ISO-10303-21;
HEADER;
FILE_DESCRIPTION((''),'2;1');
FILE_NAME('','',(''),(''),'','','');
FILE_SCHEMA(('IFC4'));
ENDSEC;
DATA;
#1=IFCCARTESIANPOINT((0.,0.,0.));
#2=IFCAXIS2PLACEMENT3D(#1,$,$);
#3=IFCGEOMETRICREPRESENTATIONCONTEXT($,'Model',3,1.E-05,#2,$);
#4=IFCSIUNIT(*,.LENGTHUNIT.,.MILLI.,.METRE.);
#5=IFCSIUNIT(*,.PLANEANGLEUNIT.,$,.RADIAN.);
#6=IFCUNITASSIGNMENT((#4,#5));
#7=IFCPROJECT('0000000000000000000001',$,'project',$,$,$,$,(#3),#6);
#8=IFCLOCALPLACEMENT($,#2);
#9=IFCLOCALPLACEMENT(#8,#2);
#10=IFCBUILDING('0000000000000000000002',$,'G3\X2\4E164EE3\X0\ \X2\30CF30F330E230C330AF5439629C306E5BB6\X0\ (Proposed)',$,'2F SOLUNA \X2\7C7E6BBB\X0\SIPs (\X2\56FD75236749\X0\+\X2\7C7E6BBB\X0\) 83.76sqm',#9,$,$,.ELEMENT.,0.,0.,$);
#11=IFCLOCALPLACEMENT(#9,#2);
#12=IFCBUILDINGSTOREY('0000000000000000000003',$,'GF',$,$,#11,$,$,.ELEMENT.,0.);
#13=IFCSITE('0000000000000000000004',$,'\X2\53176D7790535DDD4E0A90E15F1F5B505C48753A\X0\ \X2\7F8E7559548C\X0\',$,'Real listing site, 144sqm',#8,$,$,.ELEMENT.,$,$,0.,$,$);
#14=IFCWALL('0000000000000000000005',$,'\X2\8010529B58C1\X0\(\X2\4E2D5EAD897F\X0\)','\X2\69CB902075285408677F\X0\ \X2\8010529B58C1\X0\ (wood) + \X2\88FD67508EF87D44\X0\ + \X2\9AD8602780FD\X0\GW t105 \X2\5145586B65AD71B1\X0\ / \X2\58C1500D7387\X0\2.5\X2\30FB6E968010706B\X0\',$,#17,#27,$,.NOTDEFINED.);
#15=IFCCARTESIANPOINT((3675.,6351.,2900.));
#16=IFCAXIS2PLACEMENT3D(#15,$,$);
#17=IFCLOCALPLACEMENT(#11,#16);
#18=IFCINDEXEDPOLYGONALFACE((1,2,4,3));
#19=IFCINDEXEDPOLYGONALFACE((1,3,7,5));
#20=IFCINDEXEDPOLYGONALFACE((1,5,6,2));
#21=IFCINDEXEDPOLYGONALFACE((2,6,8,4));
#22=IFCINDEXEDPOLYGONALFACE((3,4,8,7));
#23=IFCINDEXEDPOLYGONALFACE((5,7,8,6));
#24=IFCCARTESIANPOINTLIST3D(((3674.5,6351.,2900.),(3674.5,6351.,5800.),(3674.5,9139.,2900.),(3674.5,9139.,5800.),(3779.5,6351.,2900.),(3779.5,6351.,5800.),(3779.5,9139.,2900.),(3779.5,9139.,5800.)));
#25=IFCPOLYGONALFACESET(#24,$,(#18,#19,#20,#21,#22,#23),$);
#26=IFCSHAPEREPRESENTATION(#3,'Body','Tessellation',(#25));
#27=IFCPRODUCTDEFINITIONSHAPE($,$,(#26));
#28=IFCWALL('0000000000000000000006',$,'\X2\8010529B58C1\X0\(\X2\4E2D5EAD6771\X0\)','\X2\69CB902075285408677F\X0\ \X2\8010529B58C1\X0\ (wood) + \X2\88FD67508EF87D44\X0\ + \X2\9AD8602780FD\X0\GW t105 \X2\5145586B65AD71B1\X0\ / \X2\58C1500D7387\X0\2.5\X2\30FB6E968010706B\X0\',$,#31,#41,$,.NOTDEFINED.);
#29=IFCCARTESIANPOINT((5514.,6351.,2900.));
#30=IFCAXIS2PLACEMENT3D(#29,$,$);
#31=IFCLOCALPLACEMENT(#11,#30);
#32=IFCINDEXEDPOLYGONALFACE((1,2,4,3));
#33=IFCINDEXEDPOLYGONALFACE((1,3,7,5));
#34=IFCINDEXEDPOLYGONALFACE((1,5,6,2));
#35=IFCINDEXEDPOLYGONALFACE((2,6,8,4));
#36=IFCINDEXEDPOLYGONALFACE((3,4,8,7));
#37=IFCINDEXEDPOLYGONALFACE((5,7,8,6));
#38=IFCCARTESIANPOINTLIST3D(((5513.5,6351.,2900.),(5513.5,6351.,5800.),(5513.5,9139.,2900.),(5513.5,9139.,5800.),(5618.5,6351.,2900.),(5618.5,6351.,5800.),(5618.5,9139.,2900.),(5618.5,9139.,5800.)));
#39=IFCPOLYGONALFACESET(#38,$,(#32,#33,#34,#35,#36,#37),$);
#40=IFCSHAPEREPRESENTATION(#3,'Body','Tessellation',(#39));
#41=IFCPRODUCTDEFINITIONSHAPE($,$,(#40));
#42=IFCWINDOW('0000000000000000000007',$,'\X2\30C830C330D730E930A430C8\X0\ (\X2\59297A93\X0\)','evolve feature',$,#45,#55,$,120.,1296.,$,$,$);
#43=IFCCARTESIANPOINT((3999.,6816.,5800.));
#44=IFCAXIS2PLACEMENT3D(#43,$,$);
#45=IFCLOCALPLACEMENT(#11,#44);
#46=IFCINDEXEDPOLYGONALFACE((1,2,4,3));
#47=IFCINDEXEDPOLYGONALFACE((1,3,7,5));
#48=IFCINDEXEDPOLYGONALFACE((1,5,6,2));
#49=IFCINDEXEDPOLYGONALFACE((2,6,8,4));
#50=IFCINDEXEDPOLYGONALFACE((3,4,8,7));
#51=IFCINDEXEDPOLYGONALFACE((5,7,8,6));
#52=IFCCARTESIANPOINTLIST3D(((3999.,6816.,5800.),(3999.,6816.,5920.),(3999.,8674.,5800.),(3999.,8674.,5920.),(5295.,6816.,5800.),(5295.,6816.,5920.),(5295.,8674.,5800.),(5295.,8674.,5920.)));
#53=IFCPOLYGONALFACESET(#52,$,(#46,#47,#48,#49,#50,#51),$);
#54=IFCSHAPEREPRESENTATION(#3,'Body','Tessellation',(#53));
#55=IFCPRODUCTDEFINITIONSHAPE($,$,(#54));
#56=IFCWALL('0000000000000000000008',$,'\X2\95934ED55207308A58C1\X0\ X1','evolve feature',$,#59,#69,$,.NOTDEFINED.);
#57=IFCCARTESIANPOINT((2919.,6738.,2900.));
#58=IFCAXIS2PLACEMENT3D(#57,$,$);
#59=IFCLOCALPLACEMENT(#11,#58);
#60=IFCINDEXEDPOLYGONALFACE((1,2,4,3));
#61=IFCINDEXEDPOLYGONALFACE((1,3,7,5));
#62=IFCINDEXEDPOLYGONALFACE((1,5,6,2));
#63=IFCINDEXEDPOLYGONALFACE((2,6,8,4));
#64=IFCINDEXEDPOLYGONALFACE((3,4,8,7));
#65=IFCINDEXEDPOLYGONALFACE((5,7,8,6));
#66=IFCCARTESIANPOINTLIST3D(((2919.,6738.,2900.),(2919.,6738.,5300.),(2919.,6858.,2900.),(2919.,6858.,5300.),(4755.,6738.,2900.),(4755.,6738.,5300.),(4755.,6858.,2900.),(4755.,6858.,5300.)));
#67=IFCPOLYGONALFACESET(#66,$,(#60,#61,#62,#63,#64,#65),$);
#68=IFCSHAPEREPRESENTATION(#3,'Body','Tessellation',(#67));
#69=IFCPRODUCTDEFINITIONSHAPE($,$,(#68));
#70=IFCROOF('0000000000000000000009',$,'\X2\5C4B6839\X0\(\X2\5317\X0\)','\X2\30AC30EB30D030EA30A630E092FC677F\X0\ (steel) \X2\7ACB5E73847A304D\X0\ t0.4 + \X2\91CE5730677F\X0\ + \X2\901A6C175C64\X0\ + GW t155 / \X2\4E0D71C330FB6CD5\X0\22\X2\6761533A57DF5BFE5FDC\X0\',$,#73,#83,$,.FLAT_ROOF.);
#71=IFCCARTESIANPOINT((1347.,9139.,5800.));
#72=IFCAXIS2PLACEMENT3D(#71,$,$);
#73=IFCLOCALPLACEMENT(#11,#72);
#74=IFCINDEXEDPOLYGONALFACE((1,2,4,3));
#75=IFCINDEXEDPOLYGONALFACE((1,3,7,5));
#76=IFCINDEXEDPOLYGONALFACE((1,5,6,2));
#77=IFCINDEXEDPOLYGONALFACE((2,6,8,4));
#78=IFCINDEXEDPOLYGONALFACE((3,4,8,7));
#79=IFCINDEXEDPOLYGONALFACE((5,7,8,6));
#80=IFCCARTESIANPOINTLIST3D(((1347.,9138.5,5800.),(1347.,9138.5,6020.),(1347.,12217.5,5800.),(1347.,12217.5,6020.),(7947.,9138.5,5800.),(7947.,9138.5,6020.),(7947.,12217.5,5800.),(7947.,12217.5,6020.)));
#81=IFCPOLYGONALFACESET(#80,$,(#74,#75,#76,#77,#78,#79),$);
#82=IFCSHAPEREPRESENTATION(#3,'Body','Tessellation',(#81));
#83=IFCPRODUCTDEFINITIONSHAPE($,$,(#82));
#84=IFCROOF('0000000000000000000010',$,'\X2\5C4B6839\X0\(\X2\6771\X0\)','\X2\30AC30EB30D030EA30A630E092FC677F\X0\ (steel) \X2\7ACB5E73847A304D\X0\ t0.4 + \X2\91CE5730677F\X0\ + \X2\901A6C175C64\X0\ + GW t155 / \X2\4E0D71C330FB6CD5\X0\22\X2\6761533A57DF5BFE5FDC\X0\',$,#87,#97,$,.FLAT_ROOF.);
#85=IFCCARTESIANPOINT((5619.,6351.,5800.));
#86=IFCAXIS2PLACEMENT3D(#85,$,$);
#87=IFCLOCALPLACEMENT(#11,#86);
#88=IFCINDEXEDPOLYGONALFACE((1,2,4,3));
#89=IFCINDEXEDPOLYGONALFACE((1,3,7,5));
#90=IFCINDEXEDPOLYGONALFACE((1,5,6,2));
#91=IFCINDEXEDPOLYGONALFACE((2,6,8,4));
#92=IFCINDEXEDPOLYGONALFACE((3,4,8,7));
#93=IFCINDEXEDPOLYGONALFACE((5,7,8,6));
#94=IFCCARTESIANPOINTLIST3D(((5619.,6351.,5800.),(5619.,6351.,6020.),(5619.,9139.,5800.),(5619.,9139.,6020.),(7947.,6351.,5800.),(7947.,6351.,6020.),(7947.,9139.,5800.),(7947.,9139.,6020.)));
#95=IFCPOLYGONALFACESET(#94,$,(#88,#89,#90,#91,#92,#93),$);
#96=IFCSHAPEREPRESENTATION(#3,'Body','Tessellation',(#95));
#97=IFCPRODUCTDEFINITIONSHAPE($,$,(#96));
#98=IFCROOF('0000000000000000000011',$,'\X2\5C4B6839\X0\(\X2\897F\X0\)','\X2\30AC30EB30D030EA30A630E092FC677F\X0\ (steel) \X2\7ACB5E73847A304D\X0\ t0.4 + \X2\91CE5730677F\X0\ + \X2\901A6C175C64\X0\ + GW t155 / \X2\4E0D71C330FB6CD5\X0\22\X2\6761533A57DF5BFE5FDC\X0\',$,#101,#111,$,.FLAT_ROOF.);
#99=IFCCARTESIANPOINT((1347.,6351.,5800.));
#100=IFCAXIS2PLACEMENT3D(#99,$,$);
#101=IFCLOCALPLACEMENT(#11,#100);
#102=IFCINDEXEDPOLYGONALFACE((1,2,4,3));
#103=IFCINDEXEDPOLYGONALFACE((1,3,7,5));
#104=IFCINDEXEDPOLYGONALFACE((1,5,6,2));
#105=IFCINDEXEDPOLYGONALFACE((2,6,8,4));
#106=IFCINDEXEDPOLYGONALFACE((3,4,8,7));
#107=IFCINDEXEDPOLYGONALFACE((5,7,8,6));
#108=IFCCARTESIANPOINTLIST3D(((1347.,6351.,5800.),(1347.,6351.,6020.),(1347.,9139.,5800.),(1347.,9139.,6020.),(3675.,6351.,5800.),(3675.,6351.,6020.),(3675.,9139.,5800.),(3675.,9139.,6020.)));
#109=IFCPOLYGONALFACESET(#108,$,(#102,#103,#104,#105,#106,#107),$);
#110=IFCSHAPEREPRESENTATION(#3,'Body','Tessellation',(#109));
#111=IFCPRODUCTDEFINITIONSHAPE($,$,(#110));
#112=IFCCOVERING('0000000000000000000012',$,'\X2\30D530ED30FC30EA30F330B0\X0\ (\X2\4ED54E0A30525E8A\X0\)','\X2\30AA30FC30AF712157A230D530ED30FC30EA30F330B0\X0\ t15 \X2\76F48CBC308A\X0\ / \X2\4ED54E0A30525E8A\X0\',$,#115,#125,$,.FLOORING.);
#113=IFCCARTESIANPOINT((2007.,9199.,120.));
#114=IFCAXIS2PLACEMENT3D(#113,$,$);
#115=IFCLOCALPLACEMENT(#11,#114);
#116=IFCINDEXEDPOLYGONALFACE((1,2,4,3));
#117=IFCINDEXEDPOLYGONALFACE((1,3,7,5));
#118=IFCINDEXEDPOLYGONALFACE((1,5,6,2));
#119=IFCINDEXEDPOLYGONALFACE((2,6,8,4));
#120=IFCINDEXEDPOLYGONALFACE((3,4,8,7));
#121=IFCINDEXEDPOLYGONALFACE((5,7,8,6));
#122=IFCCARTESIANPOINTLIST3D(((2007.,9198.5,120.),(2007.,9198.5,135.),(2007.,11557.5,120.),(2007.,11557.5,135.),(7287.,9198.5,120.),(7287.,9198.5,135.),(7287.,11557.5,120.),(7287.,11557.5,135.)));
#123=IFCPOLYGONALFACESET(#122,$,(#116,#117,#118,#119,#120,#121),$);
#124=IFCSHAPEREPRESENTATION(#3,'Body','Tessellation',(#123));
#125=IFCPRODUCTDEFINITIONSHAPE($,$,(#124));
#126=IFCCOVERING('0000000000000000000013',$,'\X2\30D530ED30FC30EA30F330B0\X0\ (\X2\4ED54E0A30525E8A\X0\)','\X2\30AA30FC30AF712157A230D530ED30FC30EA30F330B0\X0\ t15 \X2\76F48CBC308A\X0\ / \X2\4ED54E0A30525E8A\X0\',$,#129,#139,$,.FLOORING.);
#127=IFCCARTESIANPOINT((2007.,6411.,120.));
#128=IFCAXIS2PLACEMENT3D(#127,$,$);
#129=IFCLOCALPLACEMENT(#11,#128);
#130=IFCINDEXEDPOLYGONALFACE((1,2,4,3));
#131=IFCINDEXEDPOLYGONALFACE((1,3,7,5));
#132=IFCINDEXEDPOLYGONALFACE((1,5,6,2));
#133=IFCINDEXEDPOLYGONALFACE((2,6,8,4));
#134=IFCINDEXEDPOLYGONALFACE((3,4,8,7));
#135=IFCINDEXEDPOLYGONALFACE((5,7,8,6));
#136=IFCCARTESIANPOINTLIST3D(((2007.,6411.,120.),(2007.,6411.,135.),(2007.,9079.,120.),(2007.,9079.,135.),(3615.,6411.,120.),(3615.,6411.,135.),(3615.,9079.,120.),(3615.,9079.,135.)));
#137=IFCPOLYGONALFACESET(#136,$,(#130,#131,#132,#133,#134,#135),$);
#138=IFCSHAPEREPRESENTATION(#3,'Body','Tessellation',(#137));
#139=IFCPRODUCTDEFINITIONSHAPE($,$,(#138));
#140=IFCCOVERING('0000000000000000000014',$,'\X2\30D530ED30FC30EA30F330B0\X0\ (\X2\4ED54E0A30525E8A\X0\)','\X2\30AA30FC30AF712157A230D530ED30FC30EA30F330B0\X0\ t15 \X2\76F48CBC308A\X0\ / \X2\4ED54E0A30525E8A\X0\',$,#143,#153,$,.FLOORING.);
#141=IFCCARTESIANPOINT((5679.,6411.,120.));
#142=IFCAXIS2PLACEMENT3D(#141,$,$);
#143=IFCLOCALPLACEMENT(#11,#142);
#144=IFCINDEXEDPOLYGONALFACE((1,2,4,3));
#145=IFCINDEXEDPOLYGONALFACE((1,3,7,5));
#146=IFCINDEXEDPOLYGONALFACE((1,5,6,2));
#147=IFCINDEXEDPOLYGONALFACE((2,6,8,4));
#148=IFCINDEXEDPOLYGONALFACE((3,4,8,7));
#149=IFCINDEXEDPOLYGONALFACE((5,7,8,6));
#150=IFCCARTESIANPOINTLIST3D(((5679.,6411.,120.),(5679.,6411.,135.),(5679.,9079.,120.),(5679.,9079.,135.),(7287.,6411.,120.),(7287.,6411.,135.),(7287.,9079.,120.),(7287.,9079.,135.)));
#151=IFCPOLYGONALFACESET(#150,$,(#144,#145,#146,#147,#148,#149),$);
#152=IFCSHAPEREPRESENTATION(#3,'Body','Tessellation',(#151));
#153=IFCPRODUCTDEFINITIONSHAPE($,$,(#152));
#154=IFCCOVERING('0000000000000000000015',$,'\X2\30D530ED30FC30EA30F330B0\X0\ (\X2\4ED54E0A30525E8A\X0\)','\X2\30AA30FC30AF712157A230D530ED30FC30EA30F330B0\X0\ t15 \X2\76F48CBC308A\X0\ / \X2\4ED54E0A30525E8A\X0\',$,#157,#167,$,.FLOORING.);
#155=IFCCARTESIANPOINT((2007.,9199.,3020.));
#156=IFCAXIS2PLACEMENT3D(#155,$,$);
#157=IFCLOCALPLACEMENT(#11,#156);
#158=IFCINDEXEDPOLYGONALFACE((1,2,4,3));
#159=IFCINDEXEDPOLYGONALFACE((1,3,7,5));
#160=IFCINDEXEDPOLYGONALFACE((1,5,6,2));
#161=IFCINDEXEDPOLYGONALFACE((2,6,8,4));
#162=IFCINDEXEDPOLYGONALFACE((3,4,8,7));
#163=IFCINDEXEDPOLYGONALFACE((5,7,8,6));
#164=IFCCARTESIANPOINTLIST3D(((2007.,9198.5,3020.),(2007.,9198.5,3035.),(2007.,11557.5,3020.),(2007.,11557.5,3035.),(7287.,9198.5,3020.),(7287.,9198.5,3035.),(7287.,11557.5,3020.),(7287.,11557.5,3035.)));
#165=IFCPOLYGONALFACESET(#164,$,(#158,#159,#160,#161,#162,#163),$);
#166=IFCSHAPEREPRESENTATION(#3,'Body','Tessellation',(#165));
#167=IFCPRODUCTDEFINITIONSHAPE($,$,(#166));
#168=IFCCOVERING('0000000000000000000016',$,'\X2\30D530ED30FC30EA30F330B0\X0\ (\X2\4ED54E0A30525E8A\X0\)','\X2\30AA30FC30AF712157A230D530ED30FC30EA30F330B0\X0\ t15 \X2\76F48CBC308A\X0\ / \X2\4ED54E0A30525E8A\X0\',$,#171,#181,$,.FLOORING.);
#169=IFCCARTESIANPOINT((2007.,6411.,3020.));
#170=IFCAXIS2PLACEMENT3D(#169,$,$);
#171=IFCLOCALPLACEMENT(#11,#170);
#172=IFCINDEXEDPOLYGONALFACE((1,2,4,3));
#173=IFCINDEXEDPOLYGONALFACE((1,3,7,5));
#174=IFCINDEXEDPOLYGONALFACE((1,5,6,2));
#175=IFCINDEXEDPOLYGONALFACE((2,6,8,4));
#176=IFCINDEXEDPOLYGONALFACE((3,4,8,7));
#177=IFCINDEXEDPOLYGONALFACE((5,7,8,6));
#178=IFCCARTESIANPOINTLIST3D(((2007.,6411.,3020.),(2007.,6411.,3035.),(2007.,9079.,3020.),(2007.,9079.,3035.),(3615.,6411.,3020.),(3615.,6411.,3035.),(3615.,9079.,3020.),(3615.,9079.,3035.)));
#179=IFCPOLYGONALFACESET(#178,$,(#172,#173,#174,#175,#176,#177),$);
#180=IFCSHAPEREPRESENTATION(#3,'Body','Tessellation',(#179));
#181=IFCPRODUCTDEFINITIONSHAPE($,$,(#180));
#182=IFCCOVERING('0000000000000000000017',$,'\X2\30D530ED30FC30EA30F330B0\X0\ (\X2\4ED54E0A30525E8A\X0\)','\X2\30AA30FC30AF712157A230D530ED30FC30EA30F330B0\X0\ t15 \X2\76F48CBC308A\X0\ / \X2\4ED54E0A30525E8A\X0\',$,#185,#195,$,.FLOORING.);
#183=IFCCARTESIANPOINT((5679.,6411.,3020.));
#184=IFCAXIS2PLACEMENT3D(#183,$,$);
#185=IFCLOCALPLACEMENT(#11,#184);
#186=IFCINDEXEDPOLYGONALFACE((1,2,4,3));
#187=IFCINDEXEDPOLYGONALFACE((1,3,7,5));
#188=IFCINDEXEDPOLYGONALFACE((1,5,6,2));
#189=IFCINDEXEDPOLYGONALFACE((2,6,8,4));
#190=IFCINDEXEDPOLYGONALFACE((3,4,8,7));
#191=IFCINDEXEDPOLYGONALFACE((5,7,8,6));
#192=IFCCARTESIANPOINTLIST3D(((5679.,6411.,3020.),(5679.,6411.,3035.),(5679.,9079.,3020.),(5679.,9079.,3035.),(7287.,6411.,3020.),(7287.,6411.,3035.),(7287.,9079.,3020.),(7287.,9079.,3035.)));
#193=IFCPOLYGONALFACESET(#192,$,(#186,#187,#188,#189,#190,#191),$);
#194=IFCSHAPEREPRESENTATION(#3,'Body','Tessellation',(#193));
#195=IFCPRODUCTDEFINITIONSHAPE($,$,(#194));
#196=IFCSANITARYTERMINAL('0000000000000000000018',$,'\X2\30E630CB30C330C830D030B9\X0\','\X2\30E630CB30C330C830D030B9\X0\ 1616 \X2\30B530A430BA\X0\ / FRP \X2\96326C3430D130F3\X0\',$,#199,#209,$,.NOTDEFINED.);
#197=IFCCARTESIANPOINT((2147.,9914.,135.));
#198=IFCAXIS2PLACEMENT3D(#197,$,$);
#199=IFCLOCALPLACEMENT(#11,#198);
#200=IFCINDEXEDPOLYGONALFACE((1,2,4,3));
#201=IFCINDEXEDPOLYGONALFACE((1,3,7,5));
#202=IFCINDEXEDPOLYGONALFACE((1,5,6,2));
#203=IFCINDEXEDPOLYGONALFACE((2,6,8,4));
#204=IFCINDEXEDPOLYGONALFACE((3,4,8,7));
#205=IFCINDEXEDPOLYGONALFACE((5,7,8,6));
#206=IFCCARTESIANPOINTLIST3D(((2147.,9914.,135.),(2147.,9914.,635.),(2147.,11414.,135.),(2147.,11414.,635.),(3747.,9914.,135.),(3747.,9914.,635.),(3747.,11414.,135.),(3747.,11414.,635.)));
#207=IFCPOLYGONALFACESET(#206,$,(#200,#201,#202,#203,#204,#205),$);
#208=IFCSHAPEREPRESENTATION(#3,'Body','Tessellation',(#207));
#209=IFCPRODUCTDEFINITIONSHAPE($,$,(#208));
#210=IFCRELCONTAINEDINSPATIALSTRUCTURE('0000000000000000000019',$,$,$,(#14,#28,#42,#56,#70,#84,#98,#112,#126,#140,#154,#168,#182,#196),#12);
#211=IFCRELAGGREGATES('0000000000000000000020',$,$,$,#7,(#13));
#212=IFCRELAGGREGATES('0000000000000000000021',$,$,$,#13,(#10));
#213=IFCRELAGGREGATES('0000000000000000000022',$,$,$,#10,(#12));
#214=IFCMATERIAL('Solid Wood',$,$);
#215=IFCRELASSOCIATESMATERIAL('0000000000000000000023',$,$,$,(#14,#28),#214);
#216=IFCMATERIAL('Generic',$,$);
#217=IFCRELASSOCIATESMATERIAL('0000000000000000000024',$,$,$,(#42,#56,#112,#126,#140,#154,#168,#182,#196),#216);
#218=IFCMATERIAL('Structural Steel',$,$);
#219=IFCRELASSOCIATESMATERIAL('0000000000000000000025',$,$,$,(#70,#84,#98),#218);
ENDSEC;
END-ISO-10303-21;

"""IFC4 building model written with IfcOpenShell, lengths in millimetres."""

from ifc_helpers import new_model, si_unit, frame, frame_2d, origin, place, context, project, spatial, rectangle, extrude, material, element, save


model = new_model("IFC4")

# Units and contexts
model_context = context("Model", 3, precision=1e-05, world=origin())
ifc_project = project(units=[si_unit("LENGTHUNIT", "METRE", prefix="MILLI"), si_unit("PLANEANGLEUNIT", "RADIAN")], contexts=[model_context])

# Site, building, storey
site_placement = place(None, origin())
site = spatial("IfcSite", under=ifc_project, at=site_placement, Name="北海道川上郡弟子屈町 美留和", ObjectType="Real listing site, 144sqm", CompositionType="ELEMENT", RefElevation=0.0)
building_placement = place(site_placement, origin())
building = spatial("IfcBuilding", under=site, at=building_placement, Name="G3世代 ハンモック吹抜の家 (Proposed)", ObjectType="2F SOLUNA 籾殻SIPs (国産杉+籾殻) 83.76sqm", CompositionType="ELEMENT", ElevationOfRefHeight=0.0, ElevationOfTerrain=0.0)
storey_placement = place(building_placement, origin())
storey = spatial("IfcBuildingStorey", under=building, at=storey_placement, Name="GF", CompositionType="ELEMENT", Elevation=0.0)

# Shared definitions
ifc_material_1 = material(Name="Solid Wood")

# Walls
wall_1_placement = place(storey_placement, frame((3675.0, 6351.0, 2900.0)))
element("IfcWall", 1, at=wall_1_placement, inside=storey, material=ifc_material_1, Name="耐力壁(中庭西)", Description="構造用合板 耐力壁 (wood) + 製材軸組 + 高性能GW t105 充填断熱 / 壁倍率2.5・準耐火", PredefinedType="NOTDEFINED", context=model_context, shape_type="SweptSolid", body=[
    extrude(rectangle(XDim=105.0, YDim=2788.0, at=frame_2d((52.0, 1394.0))), frame((3675.0, 6351.0, 2900.0)), (0.0, 0.0, 1.0), 2900.0),
])
wall_2_placement = place(storey_placement, frame((5514.0, 6351.0, 2900.0)))
element("IfcWall", 2, at=wall_2_placement, inside=storey, material=ifc_material_1, Name="耐力壁(中庭東)", Description="構造用合板 耐力壁 (wood) + 製材軸組 + 高性能GW t105 充填断熱 / 壁倍率2.5・準耐火", PredefinedType="NOTDEFINED", context=model_context, shape_type="SweptSolid", body=[
    extrude(rectangle(XDim=105.0, YDim=2788.0, at=frame_2d((52.0, 1394.0))), frame((5514.0, 6351.0, 2900.0)), (0.0, 0.0, 1.0), 2900.0),
])

# Window
ifc_material_2 = material(Name="Generic")
window_1_placement = place(storey_placement, frame((3999.0, 6816.0, 5800.0)))
element("IfcWindow", 3, at=window_1_placement, inside=storey, material=ifc_material_2, Name="トップライト (天窓)", Description="evolve feature", OverallHeight=120.0, OverallWidth=1296.0, context=model_context, shape_type="SweptSolid", body=[
    extrude(rectangle(XDim=1296.0, YDim=1858.0, at=frame_2d((648.0, 929.0))), frame((3999.0, 6816.0, 5800.0)), (0.0, 0.0, 1.0), 120.0),
])

# Wall
wall_3_placement = place(storey_placement, frame((2919.0, 6738.0, 2900.0)))
element("IfcWall", 4, at=wall_3_placement, inside=storey, material=ifc_material_2, Name="間仕切り壁 X1", Description="evolve feature", PredefinedType="NOTDEFINED", context=model_context, shape_type="SweptSolid", body=[
    extrude(rectangle(XDim=1836.0, YDim=120.0, at=frame_2d((918.0, 60.0))), frame((2919.0, 6738.0, 2900.0)), (0.0, 0.0, 1.0), 2400.0),
])

# Roofs
ifc_material_3 = material(Name="Structural Steel")
roof_1_placement = place(storey_placement, frame((1347.0, 9139.0, 5800.0)))
element("IfcRoof", 5, at=roof_1_placement, inside=storey, material=ifc_material_3, Name="屋根(北)", Description="ガルバリウム鋼板 (steel) 立平葺き t0.4 + 野地板 + 通気層 + GW t155 / 不燃・法22条区域対応", PredefinedType="FLAT_ROOF", context=model_context, shape_type="SweptSolid", body=[
    extrude(rectangle(XDim=6600.0, YDim=3079.0, at=frame_2d((3300.0, 1539.0))), frame((1347.0, 9139.0, 5800.0)), (0.0, 0.0, 1.0), 220.0),
])
roof_2_placement = place(storey_placement, frame((5619.0, 6351.0, 5800.0)))
element("IfcRoof", 6, at=roof_2_placement, inside=storey, material=ifc_material_3, Name="屋根(東)", Description="ガルバリウム鋼板 (steel) 立平葺き t0.4 + 野地板 + 通気層 + GW t155 / 不燃・法22条区域対応", PredefinedType="FLAT_ROOF", context=model_context, shape_type="SweptSolid", body=[
    extrude(rectangle(XDim=2328.0, YDim=2788.0, at=frame_2d((1164.0, 1394.0))), frame((5619.0, 6351.0, 5800.0)), (0.0, 0.0, 1.0), 220.0),
])
roof_3_placement = place(storey_placement, frame((1347.0, 6351.0, 5800.0)))
element("IfcRoof", 7, at=roof_3_placement, inside=storey, material=ifc_material_3, Name="屋根(西)", Description="ガルバリウム鋼板 (steel) 立平葺き t0.4 + 野地板 + 通気層 + GW t155 / 不燃・法22条区域対応", PredefinedType="FLAT_ROOF", context=model_context, shape_type="SweptSolid", body=[
    extrude(rectangle(XDim=2328.0, YDim=2788.0, at=frame_2d((1164.0, 1394.0))), frame((1347.0, 6351.0, 5800.0)), (0.0, 0.0, 1.0), 220.0),
])

# Coverings
covering_1_placement = place(storey_placement, frame((2007.0, 9199.0, 120.0)))
element("IfcCovering", 8, at=covering_1_placement, inside=storey, material=ifc_material_2, Name="フローリング (仕上げ床)", Description="オーク無垢フローリング t15 直貼り / 仕上げ床", PredefinedType="FLOORING", context=model_context, shape_type="SweptSolid", body=[
    extrude(rectangle(XDim=5280.0, YDim=2359.0, at=frame_2d((2640.0, 1179.0))), frame((2007.0, 9199.0, 120.0)), (0.0, 0.0, 1.0), 15.0),
])
covering_2_placement = place(storey_placement, frame((2007.0, 6411.0, 120.0)))
element("IfcCovering", 9, at=covering_2_placement, inside=storey, material=ifc_material_2, Name="フローリング (仕上げ床)", Description="オーク無垢フローリング t15 直貼り / 仕上げ床", PredefinedType="FLOORING", context=model_context, shape_type="SweptSolid", body=[
    extrude(rectangle(XDim=1608.0, YDim=2668.0, at=frame_2d((804.0, 1334.0))), frame((2007.0, 6411.0, 120.0)), (0.0, 0.0, 1.0), 15.0),
])
covering_3_placement = place(storey_placement, frame((5679.0, 6411.0, 120.0)))
element("IfcCovering", 10, at=covering_3_placement, inside=storey, material=ifc_material_2, Name="フローリング (仕上げ床)", Description="オーク無垢フローリング t15 直貼り / 仕上げ床", PredefinedType="FLOORING", context=model_context, shape_type="SweptSolid", body=[
    extrude(rectangle(XDim=1608.0, YDim=2668.0, at=frame_2d((804.0, 1334.0))), frame((5679.0, 6411.0, 120.0)), (0.0, 0.0, 1.0), 15.0),
])
covering_4_placement = place(storey_placement, frame((2007.0, 9199.0, 3020.0)))
element("IfcCovering", 11, at=covering_4_placement, inside=storey, material=ifc_material_2, Name="フローリング (仕上げ床)", Description="オーク無垢フローリング t15 直貼り / 仕上げ床", PredefinedType="FLOORING", context=model_context, shape_type="SweptSolid", body=[
    extrude(rectangle(XDim=5280.0, YDim=2359.0, at=frame_2d((2640.0, 1179.0))), frame((2007.0, 9199.0, 3020.0)), (0.0, 0.0, 1.0), 15.0),
])
covering_5_placement = place(storey_placement, frame((2007.0, 6411.0, 3020.0)))
element("IfcCovering", 12, at=covering_5_placement, inside=storey, material=ifc_material_2, Name="フローリング (仕上げ床)", Description="オーク無垢フローリング t15 直貼り / 仕上げ床", PredefinedType="FLOORING", context=model_context, shape_type="SweptSolid", body=[
    extrude(rectangle(XDim=1608.0, YDim=2668.0, at=frame_2d((804.0, 1334.0))), frame((2007.0, 6411.0, 3020.0)), (0.0, 0.0, 1.0), 15.0),
])
covering_6_placement = place(storey_placement, frame((5679.0, 6411.0, 3020.0)))
element("IfcCovering", 13, at=covering_6_placement, inside=storey, material=ifc_material_2, Name="フローリング (仕上げ床)", Description="オーク無垢フローリング t15 直貼り / 仕上げ床", PredefinedType="FLOORING", context=model_context, shape_type="SweptSolid", body=[
    extrude(rectangle(XDim=1608.0, YDim=2668.0, at=frame_2d((804.0, 1334.0))), frame((5679.0, 6411.0, 3020.0)), (0.0, 0.0, 1.0), 15.0),
])

# Sanitary terminal
sanitary_terminal_1_placement = place(storey_placement, frame((2147.0, 9914.0, 135.0)))
element("IfcSanitaryTerminal", 14, at=sanitary_terminal_1_placement, inside=storey, material=ifc_material_2, Name="ユニットバス", Description="ユニットバス 1616 サイズ / FRP 防水パン", PredefinedType="NOTDEFINED", context=model_context, shape_type="SweptSolid", body=[
    extrude(rectangle(XDim=1600.0, YDim=1500.0, at=frame_2d((800.0, 750.0))), frame((2147.0, 9914.0, 135.0)), (0.0, 0.0, 1.0), 500.0),
])

save(model, "model.ifc")
